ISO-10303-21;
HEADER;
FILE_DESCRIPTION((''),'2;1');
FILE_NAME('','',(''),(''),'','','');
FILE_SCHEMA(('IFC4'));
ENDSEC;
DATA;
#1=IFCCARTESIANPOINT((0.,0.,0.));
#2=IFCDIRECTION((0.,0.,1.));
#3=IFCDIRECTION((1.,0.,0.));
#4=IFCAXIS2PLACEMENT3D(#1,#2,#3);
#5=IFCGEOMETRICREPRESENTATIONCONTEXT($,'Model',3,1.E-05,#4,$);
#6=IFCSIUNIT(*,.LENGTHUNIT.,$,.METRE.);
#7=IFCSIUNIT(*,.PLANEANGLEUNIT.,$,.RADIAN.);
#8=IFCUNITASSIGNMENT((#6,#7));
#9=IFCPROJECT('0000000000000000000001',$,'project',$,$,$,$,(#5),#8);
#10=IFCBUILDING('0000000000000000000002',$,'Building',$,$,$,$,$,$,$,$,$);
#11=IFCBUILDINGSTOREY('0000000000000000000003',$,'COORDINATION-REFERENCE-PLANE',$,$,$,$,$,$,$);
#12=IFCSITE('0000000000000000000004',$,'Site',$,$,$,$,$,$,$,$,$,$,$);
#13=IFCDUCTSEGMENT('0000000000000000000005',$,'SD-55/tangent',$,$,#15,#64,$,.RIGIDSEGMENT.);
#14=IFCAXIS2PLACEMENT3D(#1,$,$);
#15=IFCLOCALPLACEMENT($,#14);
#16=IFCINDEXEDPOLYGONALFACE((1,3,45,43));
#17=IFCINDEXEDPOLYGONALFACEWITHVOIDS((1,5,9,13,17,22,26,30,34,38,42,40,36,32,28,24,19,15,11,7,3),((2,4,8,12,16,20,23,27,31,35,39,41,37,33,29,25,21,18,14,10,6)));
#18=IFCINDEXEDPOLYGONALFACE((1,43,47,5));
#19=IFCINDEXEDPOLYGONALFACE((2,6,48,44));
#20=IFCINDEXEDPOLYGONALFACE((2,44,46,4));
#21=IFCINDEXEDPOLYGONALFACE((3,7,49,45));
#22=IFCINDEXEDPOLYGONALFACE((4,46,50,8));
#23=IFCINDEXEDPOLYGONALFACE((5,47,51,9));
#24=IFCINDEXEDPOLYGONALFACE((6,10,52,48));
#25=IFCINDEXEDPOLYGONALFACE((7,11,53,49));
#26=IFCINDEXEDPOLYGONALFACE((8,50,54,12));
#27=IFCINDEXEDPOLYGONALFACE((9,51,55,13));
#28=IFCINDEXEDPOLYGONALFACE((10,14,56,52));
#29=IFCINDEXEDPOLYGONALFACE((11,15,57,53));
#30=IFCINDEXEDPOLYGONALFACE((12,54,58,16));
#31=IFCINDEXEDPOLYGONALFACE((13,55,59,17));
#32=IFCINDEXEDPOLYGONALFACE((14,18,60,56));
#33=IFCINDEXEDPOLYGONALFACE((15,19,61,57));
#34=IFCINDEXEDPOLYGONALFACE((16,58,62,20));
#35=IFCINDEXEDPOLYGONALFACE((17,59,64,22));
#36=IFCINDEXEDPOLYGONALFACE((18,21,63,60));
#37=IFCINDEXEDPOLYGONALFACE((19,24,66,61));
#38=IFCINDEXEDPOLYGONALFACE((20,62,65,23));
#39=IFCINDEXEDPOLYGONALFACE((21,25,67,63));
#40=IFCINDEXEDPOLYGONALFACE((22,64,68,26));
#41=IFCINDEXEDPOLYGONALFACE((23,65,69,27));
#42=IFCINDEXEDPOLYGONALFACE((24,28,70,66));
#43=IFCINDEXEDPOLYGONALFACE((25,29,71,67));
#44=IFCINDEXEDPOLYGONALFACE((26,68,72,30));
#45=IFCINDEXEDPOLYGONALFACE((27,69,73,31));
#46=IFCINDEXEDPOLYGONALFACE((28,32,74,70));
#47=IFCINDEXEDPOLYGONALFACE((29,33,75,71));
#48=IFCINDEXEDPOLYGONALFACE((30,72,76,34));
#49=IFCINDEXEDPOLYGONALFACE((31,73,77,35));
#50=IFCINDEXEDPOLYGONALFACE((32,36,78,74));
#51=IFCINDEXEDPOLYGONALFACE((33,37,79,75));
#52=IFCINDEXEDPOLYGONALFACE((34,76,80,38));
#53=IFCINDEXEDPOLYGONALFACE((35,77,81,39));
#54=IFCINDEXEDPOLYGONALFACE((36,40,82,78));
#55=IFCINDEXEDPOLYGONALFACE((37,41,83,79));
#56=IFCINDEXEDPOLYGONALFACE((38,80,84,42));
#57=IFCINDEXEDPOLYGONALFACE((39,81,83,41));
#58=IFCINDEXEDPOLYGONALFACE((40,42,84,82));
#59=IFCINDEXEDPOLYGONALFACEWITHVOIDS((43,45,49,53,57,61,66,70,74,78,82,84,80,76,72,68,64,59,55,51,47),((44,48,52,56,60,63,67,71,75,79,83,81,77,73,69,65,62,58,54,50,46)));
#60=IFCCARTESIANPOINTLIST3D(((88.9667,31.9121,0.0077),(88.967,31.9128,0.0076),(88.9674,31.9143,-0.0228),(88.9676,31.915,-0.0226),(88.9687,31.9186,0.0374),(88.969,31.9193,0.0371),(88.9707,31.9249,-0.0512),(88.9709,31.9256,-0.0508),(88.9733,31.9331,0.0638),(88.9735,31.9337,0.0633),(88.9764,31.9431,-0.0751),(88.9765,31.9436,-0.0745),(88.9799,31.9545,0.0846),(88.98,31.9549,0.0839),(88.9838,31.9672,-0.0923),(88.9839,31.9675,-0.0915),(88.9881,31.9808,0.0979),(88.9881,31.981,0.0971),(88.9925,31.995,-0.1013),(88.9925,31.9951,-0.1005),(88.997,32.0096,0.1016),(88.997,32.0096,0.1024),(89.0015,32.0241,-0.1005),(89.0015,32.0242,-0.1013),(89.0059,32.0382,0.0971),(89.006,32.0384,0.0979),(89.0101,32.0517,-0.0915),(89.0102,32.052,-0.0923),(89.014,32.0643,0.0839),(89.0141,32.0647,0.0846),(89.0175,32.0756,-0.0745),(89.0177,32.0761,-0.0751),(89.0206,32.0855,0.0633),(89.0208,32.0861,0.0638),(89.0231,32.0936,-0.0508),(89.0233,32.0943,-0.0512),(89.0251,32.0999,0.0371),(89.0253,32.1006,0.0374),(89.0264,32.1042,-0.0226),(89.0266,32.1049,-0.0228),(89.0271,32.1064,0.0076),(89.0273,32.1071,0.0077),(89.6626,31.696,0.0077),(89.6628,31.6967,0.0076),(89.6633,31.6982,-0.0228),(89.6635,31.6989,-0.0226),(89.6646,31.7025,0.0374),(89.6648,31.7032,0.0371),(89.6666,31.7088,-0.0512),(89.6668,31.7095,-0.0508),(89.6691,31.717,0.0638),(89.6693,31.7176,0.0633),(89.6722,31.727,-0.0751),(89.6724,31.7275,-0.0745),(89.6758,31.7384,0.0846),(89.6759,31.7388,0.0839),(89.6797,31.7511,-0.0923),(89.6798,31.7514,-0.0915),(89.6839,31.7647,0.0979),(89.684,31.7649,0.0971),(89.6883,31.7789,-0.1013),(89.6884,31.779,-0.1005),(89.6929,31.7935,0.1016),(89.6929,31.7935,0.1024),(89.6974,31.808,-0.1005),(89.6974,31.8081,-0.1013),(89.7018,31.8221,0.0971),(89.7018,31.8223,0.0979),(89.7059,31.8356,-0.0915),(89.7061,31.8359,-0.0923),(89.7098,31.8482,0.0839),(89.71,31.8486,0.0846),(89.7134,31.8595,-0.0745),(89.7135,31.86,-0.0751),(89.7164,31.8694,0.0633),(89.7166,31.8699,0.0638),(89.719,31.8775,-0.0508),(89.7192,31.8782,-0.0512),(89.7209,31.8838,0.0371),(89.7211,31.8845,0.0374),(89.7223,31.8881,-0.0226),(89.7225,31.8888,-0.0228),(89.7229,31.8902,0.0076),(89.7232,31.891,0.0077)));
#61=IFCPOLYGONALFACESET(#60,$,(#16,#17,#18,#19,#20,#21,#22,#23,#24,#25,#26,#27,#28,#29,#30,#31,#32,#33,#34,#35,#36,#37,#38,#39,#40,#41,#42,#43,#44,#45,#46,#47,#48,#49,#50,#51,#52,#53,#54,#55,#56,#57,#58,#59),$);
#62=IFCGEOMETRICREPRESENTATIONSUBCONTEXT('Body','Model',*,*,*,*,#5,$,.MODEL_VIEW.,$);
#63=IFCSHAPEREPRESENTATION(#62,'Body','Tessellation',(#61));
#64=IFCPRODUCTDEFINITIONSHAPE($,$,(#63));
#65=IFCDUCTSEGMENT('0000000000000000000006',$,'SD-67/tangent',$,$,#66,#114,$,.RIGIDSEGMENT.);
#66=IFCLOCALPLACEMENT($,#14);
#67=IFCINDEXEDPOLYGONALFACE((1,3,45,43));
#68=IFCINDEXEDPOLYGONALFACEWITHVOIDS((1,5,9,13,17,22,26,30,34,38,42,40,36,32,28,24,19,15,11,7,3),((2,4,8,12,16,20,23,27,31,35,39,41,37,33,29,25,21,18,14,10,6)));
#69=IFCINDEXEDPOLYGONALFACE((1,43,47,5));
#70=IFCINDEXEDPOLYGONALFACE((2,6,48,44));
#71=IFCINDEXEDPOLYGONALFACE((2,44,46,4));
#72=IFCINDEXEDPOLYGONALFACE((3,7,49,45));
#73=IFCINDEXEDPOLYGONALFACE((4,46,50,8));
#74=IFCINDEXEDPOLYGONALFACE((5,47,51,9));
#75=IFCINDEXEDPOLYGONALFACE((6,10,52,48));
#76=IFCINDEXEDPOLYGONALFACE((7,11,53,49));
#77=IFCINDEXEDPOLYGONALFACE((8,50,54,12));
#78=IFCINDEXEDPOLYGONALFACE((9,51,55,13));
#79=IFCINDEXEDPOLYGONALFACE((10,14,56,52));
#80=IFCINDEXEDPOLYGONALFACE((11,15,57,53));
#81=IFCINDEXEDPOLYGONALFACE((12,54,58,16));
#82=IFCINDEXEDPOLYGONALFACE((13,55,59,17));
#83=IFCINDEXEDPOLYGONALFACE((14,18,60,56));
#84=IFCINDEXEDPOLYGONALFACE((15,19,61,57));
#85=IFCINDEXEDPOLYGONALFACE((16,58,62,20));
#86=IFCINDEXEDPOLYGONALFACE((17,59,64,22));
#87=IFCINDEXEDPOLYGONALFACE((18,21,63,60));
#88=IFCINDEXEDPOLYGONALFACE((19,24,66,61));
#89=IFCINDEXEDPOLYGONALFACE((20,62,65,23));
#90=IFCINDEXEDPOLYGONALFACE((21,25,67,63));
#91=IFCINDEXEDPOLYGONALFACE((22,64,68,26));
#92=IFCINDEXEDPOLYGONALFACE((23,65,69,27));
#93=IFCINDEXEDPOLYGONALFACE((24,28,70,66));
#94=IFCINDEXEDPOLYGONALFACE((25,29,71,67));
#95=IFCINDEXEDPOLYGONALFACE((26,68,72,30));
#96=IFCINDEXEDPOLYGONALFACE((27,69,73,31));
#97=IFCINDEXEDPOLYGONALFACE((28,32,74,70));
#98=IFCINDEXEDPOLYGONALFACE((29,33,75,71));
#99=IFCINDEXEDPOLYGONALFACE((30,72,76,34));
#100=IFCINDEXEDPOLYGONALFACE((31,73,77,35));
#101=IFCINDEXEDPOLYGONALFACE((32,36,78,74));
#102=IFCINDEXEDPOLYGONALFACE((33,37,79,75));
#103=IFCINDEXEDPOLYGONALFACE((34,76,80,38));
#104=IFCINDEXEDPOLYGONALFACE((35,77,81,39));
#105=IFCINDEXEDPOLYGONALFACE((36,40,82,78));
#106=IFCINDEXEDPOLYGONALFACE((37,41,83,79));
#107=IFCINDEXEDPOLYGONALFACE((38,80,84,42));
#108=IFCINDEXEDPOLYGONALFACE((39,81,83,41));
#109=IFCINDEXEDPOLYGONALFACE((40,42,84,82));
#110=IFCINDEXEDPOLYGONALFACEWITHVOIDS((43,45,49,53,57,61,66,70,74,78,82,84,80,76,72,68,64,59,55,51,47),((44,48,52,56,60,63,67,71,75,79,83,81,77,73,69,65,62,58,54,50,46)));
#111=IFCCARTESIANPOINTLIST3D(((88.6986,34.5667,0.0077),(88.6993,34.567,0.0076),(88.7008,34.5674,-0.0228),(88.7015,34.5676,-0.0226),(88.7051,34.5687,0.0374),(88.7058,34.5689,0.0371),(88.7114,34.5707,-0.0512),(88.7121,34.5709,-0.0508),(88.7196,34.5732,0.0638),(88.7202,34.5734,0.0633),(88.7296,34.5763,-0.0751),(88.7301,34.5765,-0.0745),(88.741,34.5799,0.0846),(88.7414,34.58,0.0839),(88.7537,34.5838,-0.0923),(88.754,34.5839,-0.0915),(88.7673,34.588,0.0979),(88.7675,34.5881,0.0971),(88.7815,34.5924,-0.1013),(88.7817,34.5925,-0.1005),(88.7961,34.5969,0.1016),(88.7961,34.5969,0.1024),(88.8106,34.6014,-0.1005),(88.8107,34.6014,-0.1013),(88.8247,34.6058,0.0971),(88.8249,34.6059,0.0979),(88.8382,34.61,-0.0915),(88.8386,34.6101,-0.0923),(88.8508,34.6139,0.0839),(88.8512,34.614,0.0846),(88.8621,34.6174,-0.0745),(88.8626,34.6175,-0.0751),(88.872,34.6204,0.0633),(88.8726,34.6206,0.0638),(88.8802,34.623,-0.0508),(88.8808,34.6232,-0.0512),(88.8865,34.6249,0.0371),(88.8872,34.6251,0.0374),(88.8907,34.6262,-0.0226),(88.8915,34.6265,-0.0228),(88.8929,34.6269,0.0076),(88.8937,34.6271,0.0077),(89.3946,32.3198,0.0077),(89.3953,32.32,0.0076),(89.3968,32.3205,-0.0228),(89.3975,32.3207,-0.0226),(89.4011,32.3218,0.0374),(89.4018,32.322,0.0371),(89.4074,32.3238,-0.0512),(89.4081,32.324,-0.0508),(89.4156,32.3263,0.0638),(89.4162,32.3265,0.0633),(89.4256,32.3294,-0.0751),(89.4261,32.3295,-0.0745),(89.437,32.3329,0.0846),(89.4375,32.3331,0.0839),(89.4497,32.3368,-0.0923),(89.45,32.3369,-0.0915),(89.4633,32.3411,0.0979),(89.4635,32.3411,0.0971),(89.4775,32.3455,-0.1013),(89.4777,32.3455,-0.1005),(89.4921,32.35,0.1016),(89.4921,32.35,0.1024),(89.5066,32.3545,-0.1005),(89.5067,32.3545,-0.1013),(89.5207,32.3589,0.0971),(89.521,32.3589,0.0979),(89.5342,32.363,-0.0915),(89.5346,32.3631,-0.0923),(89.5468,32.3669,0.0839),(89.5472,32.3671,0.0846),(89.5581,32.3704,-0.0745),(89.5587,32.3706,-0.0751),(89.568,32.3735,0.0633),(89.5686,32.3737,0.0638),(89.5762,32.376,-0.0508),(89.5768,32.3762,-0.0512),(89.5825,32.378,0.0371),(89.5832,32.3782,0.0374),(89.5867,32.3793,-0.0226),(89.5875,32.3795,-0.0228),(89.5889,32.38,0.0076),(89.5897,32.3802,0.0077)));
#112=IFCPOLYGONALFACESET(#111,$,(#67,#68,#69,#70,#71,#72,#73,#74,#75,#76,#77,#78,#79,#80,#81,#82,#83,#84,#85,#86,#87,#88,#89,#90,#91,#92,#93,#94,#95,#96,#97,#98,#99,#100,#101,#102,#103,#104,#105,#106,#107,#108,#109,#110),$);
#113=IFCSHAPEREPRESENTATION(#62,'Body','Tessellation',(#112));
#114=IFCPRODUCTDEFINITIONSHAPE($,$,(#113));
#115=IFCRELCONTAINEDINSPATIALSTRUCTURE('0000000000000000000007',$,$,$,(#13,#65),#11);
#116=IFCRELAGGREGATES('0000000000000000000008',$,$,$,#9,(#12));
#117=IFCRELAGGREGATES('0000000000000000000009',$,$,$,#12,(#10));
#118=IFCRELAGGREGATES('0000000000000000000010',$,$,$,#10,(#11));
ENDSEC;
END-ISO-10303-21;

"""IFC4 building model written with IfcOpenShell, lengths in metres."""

from ifc_helpers import new_model, si_unit, frame, origin_with_axes, place, context, subcontext, project, spatial, hollow_circle, extrude, element, save


model = new_model("IFC4")

# Units and contexts
model_context = context("Model", 3, precision=1e-05, world=origin_with_axes())
body_context = subcontext(model_context, "Body", "Model", "MODEL_VIEW")
ifc_project = project(units=[si_unit("LENGTHUNIT", "METRE"), si_unit("PLANEANGLEUNIT", "RADIAN")], contexts=[model_context])

# Site, building, storey
site = spatial("IfcSite", under=ifc_project, Name="Site")
building = spatial("IfcBuilding", under=site, Name="Building")
storey = spatial("IfcBuildingStorey", under=building, Name="COORDINATION-REFERENCE-PLANE")

# Duct segment
duct_segment_1_placement = place(None, frame((89.6929, 31.7935, 0.0), z_axis=(-0.955005, 0.296589, 0.0), x_axis=(0.0, 0.0, 1.0)))
element("IfcDuctSegment", 1, at=duct_segment_1_placement, inside=storey, Name="SD-55/tangent", PredefinedType="RIGIDSEGMENT", context=body_context, shape_type="SweptSolid", body=[
    extrude(hollow_circle(Radius=0.1024, WallThickness=0.0008), origin_with_axes(), (0.0, 0.0, 1.0), 0.7286),
])

# Duct segment
duct_segment_2_placement = place(None, frame((89.4921, 32.35, 0.0), z_axis=(-0.295887, 0.955223, 0.0), x_axis=(0.0, 0.0, 1.0)))
element("IfcDuctSegment", 2, at=duct_segment_2_placement, inside=storey, Name="SD-67/tangent", PredefinedType="RIGIDSEGMENT", context=body_context, shape_type="SweptSolid", body=[
    extrude(hollow_circle(Radius=0.1024, WallThickness=0.0008), origin_with_axes(), (0.0, 0.0, 1.0), 2.3523),
])

save(model, "model.ifc")
